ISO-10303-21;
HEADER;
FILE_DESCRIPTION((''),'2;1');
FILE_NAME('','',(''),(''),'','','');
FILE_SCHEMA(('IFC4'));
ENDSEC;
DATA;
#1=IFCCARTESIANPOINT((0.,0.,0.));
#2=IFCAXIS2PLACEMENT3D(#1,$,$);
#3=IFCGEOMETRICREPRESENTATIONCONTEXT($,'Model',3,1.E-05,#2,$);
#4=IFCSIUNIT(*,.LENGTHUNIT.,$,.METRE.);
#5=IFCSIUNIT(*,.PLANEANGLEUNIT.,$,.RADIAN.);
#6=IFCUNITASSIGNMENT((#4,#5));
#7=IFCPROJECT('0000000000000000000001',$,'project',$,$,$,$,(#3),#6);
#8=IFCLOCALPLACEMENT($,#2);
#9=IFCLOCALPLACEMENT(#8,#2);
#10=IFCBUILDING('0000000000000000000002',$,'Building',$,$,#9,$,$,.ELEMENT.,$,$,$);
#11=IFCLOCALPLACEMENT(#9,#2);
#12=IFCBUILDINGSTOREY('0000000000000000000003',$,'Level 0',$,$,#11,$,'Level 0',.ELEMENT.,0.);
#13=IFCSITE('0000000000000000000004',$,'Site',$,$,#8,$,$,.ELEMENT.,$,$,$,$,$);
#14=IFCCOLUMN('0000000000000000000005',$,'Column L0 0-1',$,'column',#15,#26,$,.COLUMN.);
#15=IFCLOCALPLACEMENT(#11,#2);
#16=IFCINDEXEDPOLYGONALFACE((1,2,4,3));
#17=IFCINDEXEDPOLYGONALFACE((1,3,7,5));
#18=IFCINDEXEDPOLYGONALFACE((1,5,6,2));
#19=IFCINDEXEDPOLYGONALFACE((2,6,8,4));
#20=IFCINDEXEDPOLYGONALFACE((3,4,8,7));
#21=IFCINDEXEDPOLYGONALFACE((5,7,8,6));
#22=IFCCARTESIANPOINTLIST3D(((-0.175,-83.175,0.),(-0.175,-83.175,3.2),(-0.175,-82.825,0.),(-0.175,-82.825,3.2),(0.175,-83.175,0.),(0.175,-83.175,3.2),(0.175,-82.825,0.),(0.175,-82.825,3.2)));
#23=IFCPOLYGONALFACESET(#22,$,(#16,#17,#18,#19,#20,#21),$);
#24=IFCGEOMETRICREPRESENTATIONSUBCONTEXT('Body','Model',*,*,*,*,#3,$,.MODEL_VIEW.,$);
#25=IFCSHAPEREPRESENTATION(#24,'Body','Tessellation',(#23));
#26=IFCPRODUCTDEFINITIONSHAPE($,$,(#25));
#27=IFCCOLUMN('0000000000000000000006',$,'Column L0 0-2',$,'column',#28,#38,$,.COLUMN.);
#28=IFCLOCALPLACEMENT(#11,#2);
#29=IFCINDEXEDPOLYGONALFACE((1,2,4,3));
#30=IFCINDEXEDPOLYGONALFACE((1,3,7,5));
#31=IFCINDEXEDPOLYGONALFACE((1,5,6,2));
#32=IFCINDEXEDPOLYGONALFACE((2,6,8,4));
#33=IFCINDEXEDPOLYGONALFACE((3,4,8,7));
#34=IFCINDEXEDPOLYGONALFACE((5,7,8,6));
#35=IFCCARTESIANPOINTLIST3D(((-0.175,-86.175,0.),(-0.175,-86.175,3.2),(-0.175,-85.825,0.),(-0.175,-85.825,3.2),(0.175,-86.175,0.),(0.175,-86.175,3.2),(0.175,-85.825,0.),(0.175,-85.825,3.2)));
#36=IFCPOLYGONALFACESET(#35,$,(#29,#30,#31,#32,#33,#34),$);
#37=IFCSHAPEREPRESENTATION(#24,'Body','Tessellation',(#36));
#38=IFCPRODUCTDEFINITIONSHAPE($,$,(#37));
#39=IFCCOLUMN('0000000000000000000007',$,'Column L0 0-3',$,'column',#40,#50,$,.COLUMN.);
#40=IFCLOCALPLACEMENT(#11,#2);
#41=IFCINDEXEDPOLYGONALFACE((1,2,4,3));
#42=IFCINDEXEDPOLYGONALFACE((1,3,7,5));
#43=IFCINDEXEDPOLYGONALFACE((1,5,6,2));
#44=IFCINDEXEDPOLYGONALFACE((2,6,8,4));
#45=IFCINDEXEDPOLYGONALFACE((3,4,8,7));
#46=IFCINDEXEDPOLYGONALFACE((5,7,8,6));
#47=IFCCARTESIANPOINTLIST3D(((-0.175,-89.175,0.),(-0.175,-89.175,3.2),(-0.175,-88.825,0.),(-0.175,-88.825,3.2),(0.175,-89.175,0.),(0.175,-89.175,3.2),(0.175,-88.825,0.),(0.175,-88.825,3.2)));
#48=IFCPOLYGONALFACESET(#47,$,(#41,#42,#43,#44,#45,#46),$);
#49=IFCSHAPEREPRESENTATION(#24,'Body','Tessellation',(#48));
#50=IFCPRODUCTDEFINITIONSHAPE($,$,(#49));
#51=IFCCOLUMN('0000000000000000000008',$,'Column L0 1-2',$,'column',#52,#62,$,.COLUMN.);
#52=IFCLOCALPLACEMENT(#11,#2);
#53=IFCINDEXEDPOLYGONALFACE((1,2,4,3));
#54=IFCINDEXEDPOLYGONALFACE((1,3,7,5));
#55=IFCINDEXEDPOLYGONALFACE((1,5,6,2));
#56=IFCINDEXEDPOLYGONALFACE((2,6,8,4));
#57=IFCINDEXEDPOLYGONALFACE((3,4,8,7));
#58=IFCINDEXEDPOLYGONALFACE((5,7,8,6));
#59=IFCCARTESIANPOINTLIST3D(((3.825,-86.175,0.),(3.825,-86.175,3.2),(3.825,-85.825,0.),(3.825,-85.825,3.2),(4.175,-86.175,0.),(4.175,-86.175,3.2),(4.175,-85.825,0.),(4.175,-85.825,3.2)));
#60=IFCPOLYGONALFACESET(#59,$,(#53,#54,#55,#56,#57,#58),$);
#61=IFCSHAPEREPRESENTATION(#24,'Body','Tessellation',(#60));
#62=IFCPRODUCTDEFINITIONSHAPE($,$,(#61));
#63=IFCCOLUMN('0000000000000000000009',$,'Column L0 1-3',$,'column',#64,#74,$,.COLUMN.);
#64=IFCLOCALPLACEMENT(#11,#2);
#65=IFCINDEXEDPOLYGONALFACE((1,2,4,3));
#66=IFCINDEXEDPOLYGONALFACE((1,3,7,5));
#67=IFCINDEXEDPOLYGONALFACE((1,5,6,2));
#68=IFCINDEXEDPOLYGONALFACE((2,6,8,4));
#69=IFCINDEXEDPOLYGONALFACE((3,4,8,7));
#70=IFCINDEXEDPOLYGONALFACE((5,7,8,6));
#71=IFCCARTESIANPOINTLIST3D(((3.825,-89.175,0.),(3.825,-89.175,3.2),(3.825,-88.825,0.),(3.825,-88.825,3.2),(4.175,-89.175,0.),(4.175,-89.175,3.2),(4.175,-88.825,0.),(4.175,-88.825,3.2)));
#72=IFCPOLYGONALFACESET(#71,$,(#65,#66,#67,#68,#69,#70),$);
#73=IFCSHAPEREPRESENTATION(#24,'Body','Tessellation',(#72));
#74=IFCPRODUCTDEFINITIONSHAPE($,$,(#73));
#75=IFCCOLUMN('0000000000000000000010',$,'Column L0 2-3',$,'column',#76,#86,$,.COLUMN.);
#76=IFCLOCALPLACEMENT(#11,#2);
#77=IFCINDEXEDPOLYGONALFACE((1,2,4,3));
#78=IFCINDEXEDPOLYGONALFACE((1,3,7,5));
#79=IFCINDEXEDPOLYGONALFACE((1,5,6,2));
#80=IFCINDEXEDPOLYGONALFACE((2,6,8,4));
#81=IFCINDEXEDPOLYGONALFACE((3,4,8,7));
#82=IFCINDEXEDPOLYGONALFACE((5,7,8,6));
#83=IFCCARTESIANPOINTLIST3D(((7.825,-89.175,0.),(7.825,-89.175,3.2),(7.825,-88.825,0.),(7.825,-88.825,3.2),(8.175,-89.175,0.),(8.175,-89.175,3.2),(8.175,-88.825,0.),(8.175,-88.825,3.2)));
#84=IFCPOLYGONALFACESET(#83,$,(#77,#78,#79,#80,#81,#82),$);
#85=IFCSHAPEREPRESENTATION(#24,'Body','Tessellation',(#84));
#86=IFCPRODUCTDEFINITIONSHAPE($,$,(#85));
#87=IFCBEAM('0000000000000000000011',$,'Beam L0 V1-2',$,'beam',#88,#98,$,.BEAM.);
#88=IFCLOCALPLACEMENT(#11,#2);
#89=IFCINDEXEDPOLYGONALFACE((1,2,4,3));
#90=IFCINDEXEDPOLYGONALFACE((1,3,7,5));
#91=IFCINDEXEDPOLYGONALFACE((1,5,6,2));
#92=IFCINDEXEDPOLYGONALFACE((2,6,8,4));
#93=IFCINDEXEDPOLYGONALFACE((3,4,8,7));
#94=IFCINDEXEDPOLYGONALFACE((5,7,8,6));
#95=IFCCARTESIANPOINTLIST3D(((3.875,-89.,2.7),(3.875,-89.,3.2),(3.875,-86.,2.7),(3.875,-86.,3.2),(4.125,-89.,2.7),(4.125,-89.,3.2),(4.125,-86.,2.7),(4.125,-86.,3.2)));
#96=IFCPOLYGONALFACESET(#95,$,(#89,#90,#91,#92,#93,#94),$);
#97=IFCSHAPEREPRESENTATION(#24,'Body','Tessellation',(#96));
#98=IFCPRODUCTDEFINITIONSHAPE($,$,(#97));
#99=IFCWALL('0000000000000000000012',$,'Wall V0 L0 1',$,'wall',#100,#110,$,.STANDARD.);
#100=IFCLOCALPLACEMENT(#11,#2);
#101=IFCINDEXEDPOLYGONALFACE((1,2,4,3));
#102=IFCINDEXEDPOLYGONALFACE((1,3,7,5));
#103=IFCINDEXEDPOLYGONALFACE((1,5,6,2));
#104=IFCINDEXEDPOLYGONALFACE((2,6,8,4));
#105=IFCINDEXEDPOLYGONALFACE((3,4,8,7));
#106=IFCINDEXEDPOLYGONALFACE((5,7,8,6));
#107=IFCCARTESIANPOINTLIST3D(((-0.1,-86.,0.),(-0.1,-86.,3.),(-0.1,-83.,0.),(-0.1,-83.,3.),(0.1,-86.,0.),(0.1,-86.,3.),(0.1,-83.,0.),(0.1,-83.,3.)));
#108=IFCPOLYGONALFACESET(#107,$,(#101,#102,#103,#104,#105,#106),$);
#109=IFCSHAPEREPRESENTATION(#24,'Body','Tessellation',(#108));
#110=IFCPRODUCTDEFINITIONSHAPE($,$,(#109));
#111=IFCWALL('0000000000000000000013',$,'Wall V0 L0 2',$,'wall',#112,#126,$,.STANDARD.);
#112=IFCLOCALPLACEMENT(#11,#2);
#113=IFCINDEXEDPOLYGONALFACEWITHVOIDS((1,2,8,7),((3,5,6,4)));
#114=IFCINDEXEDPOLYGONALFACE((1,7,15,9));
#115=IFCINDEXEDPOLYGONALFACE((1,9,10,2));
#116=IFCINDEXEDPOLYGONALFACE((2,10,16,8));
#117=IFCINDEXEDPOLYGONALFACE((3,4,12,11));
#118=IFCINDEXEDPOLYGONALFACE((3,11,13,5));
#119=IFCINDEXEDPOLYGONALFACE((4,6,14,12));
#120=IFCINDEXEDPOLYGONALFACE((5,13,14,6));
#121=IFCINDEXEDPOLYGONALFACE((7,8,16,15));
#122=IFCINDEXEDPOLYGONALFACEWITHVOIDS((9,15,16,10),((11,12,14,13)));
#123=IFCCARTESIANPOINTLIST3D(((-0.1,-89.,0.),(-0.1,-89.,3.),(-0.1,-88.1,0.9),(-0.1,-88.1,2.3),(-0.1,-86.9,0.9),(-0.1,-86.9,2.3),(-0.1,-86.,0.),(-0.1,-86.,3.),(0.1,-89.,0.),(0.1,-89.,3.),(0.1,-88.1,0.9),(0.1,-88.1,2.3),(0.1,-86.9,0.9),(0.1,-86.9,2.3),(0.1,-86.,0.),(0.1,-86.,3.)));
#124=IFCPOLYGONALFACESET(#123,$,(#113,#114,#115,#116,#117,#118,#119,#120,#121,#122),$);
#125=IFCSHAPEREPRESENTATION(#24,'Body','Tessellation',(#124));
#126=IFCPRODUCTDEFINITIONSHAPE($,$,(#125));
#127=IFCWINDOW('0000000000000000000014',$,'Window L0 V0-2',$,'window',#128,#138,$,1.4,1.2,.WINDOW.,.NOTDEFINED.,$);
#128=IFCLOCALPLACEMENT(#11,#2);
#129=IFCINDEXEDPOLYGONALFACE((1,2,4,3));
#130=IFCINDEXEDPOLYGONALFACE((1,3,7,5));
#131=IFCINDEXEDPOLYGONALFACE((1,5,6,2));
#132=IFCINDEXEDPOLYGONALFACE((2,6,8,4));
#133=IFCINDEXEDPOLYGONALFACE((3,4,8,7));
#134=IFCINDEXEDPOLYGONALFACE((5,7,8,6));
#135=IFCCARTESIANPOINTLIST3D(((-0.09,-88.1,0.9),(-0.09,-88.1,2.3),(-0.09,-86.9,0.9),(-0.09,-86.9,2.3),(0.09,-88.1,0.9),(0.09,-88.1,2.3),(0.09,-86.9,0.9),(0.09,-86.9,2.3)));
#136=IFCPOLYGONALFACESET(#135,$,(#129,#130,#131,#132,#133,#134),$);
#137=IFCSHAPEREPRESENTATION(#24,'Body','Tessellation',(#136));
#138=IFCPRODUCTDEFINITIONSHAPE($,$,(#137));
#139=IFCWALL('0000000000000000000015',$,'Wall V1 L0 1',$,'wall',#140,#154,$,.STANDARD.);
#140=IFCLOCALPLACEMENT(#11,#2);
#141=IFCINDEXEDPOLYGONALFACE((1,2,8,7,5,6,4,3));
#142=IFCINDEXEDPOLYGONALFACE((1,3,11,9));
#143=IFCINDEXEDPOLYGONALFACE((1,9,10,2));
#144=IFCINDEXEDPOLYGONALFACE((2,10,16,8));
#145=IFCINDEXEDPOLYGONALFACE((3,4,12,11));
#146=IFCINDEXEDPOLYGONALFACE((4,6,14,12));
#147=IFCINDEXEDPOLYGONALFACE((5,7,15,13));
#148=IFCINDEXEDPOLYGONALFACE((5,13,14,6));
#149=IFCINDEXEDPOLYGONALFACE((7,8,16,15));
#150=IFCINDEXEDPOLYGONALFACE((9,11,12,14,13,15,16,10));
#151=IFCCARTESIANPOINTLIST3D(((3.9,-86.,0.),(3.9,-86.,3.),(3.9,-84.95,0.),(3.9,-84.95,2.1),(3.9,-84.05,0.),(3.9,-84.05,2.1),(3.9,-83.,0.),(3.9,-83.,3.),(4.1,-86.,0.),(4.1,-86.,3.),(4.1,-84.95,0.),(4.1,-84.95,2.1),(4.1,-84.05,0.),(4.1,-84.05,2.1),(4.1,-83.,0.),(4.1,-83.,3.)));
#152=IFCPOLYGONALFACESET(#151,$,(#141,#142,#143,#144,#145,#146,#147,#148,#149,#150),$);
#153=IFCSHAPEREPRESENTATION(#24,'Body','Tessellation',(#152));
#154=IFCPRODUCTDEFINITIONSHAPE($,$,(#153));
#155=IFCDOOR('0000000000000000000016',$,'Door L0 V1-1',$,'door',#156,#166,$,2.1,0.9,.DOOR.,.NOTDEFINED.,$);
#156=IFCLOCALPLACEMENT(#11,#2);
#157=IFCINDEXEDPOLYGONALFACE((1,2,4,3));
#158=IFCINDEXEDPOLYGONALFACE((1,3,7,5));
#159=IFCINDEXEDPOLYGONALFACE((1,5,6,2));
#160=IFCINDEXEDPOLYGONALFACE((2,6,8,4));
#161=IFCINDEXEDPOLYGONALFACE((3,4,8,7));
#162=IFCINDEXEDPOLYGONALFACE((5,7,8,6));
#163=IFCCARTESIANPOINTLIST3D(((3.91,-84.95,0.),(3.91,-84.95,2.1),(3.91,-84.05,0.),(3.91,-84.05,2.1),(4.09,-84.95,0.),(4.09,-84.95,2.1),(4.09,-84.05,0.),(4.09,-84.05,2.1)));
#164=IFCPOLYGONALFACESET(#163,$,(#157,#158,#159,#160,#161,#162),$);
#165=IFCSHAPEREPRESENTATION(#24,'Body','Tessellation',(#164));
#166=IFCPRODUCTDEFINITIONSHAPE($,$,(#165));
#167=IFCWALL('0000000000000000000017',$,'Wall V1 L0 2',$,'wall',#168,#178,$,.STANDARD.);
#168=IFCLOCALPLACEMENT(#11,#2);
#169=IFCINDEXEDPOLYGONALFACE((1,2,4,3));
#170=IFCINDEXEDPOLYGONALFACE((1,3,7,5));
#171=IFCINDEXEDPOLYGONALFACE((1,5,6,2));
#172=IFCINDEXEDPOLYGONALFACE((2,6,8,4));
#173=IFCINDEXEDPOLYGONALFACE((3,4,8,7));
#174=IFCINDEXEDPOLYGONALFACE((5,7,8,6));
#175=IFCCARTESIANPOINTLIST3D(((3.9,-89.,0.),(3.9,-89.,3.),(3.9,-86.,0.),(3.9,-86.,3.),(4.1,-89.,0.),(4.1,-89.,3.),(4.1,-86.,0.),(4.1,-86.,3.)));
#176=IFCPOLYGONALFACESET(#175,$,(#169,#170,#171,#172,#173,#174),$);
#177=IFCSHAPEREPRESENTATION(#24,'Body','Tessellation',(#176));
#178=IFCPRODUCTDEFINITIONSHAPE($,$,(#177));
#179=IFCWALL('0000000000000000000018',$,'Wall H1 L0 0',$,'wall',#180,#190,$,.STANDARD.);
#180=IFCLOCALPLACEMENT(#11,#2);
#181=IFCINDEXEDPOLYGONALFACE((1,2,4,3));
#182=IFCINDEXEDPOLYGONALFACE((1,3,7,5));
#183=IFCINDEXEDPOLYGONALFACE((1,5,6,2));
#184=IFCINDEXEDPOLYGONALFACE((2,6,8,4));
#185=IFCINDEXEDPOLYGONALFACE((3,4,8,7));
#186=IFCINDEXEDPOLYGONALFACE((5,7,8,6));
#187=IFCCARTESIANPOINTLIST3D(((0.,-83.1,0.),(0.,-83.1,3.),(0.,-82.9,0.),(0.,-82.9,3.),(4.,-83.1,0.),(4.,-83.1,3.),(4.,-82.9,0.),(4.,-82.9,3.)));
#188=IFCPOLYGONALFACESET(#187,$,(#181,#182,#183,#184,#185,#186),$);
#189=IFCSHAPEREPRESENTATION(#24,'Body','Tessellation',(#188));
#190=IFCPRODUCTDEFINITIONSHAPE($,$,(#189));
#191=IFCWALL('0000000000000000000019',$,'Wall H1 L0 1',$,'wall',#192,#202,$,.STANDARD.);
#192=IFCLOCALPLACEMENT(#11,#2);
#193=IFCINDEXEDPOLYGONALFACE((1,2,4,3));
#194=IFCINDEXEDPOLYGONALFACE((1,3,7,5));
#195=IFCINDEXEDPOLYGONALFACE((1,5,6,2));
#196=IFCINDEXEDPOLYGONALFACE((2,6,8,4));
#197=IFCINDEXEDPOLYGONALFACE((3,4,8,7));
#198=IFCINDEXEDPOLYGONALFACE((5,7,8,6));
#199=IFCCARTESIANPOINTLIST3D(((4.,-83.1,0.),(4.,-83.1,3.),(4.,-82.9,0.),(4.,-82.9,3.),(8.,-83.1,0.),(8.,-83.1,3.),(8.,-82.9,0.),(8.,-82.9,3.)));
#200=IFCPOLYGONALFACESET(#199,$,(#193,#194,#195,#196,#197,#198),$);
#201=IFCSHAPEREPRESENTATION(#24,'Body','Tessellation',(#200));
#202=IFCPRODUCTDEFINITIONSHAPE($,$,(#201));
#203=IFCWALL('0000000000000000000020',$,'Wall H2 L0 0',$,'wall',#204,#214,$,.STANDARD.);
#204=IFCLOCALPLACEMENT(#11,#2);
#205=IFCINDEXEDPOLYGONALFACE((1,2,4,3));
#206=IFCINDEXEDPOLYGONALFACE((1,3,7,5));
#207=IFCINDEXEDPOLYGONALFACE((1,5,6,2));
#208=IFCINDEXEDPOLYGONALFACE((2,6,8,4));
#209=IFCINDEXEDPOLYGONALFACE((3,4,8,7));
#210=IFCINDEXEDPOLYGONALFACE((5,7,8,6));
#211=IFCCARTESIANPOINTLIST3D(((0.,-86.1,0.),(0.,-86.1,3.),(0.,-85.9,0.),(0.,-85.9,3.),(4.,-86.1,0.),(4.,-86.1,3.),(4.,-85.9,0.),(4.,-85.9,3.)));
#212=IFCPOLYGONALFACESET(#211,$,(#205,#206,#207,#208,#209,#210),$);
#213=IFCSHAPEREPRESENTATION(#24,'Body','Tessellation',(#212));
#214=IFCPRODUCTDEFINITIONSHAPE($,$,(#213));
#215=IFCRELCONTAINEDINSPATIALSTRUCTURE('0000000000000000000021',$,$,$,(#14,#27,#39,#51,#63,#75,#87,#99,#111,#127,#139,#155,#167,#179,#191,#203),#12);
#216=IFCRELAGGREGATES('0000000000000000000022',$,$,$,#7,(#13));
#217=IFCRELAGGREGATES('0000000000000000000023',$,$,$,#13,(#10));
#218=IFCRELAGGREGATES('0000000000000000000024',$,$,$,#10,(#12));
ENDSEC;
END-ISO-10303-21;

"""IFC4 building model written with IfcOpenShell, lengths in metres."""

from ifc_helpers import new_model, si_unit, frame, frame_2d, origin, origin_2d, place, context, subcontext, project, spatial, rectangle, extrude, element, fill, save


model = new_model("IFC4")

# Units and contexts
model_context = context("Model", 3, precision=1e-05, world=origin())
body_context = subcontext(model_context, "Body", "Model", "MODEL_VIEW")
ifc_project = project(units=[si_unit("LENGTHUNIT", "METRE"), si_unit("PLANEANGLEUNIT", "RADIAN")], contexts=[model_context])

# Site, building, storey
site_placement = place(None, origin())
site = spatial("IfcSite", under=ifc_project, at=site_placement, Name="Site", CompositionType="ELEMENT")
building_placement = place(site_placement, origin())
building = spatial("IfcBuilding", under=site, at=building_placement, Name="Building", CompositionType="ELEMENT")
storey_placement = place(building_placement, origin())
storey = spatial("IfcBuildingStorey", under=building, at=storey_placement, Name="Level 0", LongName="Level 0", CompositionType="ELEMENT", Elevation=0.0)

# Columns
for number, where, name in (
    (1, (0.0, -83.0, 0.0), "Column L0 0-1"),
    (2, (0.0, -86.0, 0.0), "Column L0 0-2"),
    (3, (0.0, -89.0, 0.0), "Column L0 0-3"),
    (4, (4.0, -86.0, 0.0), "Column L0 1-2"),
    (5, (4.0, -89.0, 0.0), "Column L0 1-3"),
    (6, (8.0, -89.0, 0.0), "Column L0 2-3"),
):
    element("IfcColumn", number, at=place(storey_placement, frame(where)), inside=storey, Name=name, ObjectType="column", PredefinedType="COLUMN", context=body_context, shape_type="SweptSolid", body=[
        extrude(rectangle(XDim=0.35, YDim=0.35, at=origin_2d()), origin(), (0.0, 0.0, 1.0), 3.2),
    ])

# Beam
beam_placement = place(storey_placement, frame((4.0, -86.0, 2.95), z_axis=(0.0, -1.0, 0.0), x_axis=(0.0, 0.0, 1.0)))
element("IfcBeam", 7, at=beam_placement, inside=storey, Name="Beam L0 V1-2", ObjectType="beam", PredefinedType="BEAM", context=body_context, shape_type="SweptSolid", body=[
    extrude(rectangle(XDim=0.5, YDim=0.25, at=origin_2d()), origin(), (0.0, 0.0, 1.0), 3.0),
])

# Wall
wall_1_placement = place(storey_placement, frame((0.0, -83.0, 0.0), z_axis=(0.0, 0.0, 1.0), x_axis=(0.0, -1.0, 0.0)))
element("IfcWall", 8, at=wall_1_placement, inside=storey, Name="Wall V0 L0 1", ObjectType="wall", PredefinedType="STANDARD", context=body_context, shape_type="SweptSolid", body=[
    extrude(rectangle(XDim=3.0, YDim=0.2, at=frame_2d((1.5, 0.0))), origin(), (0.0, 0.0, 1.0), 3.0),
])

# Wall, opening, window
wall_2_placement = place(storey_placement, frame((0.0, -86.0, 0.0), z_axis=(0.0, 0.0, 1.0), x_axis=(0.0, -1.0, 0.0)))
wall_2 = element("IfcWall", 9, at=wall_2_placement, inside=storey, Name="Wall V0 L0 2", ObjectType="wall", PredefinedType="STANDARD", context=body_context, shape_type="SweptSolid", body=[
    extrude(rectangle(XDim=3.0, YDim=0.2, at=frame_2d((1.5, 0.0))), origin(), (0.0, 0.0, 1.0), 3.0),
])
opening_1_placement = place(storey_placement, frame((0.0, -87.5, 0.9), z_axis=(0.0, 0.0, 1.0), x_axis=(0.0, -1.0, 0.0)))
opening_1 = element("IfcOpeningElement", 10, at=opening_1_placement, cuts=wall_2, ObjectType="Opening", PredefinedType="OPENING", context=body_context, shape_type="SweptSolid", body=[
    extrude(rectangle(XDim=1.2, YDim=0.22, at=origin_2d()), origin(), (0.0, 0.0, 1.0), 1.4),
])
window_1_placement = place(storey_placement, frame((0.0, -87.5, 0.9), z_axis=(0.0, 0.0, 1.0), x_axis=(0.0, -1.0, 0.0)))
window_1 = element("IfcWindow", 11, at=window_1_placement, inside=storey, Name="Window L0 V0-2", ObjectType="window", OverallHeight=1.4, OverallWidth=1.2, PartitioningType="NOTDEFINED", PredefinedType="WINDOW", context=body_context, shape_type="SweptSolid", body=[
    extrude(rectangle(XDim=1.2, YDim=0.18, at=origin_2d()), origin(), (0.0, 0.0, 1.0), 1.4),
])
fill(opening_1, window_1)

# Wall, opening, door
wall_3_placement = place(storey_placement, frame((4.0, -83.0, 0.0), z_axis=(0.0, 0.0, 1.0), x_axis=(0.0, -1.0, 0.0)))
wall_3 = element("IfcWall", 12, at=wall_3_placement, inside=storey, Name="Wall V1 L0 1", ObjectType="wall", PredefinedType="STANDARD", context=body_context, shape_type="SweptSolid", body=[
    extrude(rectangle(XDim=3.0, YDim=0.2, at=frame_2d((1.5, 0.0))), origin(), (0.0, 0.0, 1.0), 3.0),
])
opening_2_placement = place(storey_placement, frame((4.0, -84.5, 0.0), z_axis=(0.0, 0.0, 1.0), x_axis=(0.0, -1.0, 0.0)))
opening_2 = element("IfcOpeningElement", 13, at=opening_2_placement, cuts=wall_3, ObjectType="Opening", PredefinedType="OPENING", context=body_context, shape_type="SweptSolid", body=[
    extrude(rectangle(XDim=0.9, YDim=0.22, at=origin_2d()), origin(), (0.0, 0.0, 1.0), 2.1),
])
door_placement = place(storey_placement, frame((4.0, -84.5, 0.0), z_axis=(0.0, 0.0, 1.0), x_axis=(0.0, -1.0, 0.0)))
door = element("IfcDoor", 14, at=door_placement, inside=storey, Name="Door L0 V1-1", ObjectType="door", OperationType="NOTDEFINED", OverallHeight=2.1, OverallWidth=0.9, PredefinedType="DOOR", context=body_context, shape_type="SweptSolid", body=[
    extrude(rectangle(XDim=0.9, YDim=0.18, at=origin_2d()), origin(), (0.0, 0.0, 1.0), 2.1),
])
fill(opening_2, door)

# Walls
wall_4_placement = place(storey_placement, frame((4.0, -86.0, 0.0), z_axis=(0.0, 0.0, 1.0), x_axis=(0.0, -1.0, 0.0)))
element("IfcWall", 15, at=wall_4_placement, inside=storey, Name="Wall V1 L0 2", ObjectType="wall", PredefinedType="STANDARD", context=body_context, shape_type="SweptSolid", body=[
    extrude(rectangle(XDim=3.0, YDim=0.2, at=frame_2d((1.5, 0.0))), origin(), (0.0, 0.0, 1.0), 3.0),
])
for number, where, z_axis, x_axis, name in (
    (16, (0.0, -83.0, 0.0), (0.0, 0.0, 1.0), (1.0, 0.0, 0.0), "Wall H1 L0 0"),
    (17, (4.0, -83.0, 0.0), (0.0, 0.0, 1.0), (1.0, 0.0, 0.0), "Wall H1 L0 1"),
    (18, (0.0, -86.0, 0.0), (0.0, 0.0, 1.0), (1.0, 0.0, 0.0), "Wall H2 L0 0"),
):
    element("IfcWall", number, at=place(storey_placement, frame(where, z_axis=z_axis, x_axis=x_axis)), inside=storey, Name=name, ObjectType="wall", PredefinedType="STANDARD", context=body_context, shape_type="SweptSolid", body=[
        extrude(rectangle(XDim=4.0, YDim=0.2, at=frame_2d((2.0, 0.0))), origin(), (0.0, 0.0, 1.0), 3.0),
    ])

save(model, "model.ifc")
